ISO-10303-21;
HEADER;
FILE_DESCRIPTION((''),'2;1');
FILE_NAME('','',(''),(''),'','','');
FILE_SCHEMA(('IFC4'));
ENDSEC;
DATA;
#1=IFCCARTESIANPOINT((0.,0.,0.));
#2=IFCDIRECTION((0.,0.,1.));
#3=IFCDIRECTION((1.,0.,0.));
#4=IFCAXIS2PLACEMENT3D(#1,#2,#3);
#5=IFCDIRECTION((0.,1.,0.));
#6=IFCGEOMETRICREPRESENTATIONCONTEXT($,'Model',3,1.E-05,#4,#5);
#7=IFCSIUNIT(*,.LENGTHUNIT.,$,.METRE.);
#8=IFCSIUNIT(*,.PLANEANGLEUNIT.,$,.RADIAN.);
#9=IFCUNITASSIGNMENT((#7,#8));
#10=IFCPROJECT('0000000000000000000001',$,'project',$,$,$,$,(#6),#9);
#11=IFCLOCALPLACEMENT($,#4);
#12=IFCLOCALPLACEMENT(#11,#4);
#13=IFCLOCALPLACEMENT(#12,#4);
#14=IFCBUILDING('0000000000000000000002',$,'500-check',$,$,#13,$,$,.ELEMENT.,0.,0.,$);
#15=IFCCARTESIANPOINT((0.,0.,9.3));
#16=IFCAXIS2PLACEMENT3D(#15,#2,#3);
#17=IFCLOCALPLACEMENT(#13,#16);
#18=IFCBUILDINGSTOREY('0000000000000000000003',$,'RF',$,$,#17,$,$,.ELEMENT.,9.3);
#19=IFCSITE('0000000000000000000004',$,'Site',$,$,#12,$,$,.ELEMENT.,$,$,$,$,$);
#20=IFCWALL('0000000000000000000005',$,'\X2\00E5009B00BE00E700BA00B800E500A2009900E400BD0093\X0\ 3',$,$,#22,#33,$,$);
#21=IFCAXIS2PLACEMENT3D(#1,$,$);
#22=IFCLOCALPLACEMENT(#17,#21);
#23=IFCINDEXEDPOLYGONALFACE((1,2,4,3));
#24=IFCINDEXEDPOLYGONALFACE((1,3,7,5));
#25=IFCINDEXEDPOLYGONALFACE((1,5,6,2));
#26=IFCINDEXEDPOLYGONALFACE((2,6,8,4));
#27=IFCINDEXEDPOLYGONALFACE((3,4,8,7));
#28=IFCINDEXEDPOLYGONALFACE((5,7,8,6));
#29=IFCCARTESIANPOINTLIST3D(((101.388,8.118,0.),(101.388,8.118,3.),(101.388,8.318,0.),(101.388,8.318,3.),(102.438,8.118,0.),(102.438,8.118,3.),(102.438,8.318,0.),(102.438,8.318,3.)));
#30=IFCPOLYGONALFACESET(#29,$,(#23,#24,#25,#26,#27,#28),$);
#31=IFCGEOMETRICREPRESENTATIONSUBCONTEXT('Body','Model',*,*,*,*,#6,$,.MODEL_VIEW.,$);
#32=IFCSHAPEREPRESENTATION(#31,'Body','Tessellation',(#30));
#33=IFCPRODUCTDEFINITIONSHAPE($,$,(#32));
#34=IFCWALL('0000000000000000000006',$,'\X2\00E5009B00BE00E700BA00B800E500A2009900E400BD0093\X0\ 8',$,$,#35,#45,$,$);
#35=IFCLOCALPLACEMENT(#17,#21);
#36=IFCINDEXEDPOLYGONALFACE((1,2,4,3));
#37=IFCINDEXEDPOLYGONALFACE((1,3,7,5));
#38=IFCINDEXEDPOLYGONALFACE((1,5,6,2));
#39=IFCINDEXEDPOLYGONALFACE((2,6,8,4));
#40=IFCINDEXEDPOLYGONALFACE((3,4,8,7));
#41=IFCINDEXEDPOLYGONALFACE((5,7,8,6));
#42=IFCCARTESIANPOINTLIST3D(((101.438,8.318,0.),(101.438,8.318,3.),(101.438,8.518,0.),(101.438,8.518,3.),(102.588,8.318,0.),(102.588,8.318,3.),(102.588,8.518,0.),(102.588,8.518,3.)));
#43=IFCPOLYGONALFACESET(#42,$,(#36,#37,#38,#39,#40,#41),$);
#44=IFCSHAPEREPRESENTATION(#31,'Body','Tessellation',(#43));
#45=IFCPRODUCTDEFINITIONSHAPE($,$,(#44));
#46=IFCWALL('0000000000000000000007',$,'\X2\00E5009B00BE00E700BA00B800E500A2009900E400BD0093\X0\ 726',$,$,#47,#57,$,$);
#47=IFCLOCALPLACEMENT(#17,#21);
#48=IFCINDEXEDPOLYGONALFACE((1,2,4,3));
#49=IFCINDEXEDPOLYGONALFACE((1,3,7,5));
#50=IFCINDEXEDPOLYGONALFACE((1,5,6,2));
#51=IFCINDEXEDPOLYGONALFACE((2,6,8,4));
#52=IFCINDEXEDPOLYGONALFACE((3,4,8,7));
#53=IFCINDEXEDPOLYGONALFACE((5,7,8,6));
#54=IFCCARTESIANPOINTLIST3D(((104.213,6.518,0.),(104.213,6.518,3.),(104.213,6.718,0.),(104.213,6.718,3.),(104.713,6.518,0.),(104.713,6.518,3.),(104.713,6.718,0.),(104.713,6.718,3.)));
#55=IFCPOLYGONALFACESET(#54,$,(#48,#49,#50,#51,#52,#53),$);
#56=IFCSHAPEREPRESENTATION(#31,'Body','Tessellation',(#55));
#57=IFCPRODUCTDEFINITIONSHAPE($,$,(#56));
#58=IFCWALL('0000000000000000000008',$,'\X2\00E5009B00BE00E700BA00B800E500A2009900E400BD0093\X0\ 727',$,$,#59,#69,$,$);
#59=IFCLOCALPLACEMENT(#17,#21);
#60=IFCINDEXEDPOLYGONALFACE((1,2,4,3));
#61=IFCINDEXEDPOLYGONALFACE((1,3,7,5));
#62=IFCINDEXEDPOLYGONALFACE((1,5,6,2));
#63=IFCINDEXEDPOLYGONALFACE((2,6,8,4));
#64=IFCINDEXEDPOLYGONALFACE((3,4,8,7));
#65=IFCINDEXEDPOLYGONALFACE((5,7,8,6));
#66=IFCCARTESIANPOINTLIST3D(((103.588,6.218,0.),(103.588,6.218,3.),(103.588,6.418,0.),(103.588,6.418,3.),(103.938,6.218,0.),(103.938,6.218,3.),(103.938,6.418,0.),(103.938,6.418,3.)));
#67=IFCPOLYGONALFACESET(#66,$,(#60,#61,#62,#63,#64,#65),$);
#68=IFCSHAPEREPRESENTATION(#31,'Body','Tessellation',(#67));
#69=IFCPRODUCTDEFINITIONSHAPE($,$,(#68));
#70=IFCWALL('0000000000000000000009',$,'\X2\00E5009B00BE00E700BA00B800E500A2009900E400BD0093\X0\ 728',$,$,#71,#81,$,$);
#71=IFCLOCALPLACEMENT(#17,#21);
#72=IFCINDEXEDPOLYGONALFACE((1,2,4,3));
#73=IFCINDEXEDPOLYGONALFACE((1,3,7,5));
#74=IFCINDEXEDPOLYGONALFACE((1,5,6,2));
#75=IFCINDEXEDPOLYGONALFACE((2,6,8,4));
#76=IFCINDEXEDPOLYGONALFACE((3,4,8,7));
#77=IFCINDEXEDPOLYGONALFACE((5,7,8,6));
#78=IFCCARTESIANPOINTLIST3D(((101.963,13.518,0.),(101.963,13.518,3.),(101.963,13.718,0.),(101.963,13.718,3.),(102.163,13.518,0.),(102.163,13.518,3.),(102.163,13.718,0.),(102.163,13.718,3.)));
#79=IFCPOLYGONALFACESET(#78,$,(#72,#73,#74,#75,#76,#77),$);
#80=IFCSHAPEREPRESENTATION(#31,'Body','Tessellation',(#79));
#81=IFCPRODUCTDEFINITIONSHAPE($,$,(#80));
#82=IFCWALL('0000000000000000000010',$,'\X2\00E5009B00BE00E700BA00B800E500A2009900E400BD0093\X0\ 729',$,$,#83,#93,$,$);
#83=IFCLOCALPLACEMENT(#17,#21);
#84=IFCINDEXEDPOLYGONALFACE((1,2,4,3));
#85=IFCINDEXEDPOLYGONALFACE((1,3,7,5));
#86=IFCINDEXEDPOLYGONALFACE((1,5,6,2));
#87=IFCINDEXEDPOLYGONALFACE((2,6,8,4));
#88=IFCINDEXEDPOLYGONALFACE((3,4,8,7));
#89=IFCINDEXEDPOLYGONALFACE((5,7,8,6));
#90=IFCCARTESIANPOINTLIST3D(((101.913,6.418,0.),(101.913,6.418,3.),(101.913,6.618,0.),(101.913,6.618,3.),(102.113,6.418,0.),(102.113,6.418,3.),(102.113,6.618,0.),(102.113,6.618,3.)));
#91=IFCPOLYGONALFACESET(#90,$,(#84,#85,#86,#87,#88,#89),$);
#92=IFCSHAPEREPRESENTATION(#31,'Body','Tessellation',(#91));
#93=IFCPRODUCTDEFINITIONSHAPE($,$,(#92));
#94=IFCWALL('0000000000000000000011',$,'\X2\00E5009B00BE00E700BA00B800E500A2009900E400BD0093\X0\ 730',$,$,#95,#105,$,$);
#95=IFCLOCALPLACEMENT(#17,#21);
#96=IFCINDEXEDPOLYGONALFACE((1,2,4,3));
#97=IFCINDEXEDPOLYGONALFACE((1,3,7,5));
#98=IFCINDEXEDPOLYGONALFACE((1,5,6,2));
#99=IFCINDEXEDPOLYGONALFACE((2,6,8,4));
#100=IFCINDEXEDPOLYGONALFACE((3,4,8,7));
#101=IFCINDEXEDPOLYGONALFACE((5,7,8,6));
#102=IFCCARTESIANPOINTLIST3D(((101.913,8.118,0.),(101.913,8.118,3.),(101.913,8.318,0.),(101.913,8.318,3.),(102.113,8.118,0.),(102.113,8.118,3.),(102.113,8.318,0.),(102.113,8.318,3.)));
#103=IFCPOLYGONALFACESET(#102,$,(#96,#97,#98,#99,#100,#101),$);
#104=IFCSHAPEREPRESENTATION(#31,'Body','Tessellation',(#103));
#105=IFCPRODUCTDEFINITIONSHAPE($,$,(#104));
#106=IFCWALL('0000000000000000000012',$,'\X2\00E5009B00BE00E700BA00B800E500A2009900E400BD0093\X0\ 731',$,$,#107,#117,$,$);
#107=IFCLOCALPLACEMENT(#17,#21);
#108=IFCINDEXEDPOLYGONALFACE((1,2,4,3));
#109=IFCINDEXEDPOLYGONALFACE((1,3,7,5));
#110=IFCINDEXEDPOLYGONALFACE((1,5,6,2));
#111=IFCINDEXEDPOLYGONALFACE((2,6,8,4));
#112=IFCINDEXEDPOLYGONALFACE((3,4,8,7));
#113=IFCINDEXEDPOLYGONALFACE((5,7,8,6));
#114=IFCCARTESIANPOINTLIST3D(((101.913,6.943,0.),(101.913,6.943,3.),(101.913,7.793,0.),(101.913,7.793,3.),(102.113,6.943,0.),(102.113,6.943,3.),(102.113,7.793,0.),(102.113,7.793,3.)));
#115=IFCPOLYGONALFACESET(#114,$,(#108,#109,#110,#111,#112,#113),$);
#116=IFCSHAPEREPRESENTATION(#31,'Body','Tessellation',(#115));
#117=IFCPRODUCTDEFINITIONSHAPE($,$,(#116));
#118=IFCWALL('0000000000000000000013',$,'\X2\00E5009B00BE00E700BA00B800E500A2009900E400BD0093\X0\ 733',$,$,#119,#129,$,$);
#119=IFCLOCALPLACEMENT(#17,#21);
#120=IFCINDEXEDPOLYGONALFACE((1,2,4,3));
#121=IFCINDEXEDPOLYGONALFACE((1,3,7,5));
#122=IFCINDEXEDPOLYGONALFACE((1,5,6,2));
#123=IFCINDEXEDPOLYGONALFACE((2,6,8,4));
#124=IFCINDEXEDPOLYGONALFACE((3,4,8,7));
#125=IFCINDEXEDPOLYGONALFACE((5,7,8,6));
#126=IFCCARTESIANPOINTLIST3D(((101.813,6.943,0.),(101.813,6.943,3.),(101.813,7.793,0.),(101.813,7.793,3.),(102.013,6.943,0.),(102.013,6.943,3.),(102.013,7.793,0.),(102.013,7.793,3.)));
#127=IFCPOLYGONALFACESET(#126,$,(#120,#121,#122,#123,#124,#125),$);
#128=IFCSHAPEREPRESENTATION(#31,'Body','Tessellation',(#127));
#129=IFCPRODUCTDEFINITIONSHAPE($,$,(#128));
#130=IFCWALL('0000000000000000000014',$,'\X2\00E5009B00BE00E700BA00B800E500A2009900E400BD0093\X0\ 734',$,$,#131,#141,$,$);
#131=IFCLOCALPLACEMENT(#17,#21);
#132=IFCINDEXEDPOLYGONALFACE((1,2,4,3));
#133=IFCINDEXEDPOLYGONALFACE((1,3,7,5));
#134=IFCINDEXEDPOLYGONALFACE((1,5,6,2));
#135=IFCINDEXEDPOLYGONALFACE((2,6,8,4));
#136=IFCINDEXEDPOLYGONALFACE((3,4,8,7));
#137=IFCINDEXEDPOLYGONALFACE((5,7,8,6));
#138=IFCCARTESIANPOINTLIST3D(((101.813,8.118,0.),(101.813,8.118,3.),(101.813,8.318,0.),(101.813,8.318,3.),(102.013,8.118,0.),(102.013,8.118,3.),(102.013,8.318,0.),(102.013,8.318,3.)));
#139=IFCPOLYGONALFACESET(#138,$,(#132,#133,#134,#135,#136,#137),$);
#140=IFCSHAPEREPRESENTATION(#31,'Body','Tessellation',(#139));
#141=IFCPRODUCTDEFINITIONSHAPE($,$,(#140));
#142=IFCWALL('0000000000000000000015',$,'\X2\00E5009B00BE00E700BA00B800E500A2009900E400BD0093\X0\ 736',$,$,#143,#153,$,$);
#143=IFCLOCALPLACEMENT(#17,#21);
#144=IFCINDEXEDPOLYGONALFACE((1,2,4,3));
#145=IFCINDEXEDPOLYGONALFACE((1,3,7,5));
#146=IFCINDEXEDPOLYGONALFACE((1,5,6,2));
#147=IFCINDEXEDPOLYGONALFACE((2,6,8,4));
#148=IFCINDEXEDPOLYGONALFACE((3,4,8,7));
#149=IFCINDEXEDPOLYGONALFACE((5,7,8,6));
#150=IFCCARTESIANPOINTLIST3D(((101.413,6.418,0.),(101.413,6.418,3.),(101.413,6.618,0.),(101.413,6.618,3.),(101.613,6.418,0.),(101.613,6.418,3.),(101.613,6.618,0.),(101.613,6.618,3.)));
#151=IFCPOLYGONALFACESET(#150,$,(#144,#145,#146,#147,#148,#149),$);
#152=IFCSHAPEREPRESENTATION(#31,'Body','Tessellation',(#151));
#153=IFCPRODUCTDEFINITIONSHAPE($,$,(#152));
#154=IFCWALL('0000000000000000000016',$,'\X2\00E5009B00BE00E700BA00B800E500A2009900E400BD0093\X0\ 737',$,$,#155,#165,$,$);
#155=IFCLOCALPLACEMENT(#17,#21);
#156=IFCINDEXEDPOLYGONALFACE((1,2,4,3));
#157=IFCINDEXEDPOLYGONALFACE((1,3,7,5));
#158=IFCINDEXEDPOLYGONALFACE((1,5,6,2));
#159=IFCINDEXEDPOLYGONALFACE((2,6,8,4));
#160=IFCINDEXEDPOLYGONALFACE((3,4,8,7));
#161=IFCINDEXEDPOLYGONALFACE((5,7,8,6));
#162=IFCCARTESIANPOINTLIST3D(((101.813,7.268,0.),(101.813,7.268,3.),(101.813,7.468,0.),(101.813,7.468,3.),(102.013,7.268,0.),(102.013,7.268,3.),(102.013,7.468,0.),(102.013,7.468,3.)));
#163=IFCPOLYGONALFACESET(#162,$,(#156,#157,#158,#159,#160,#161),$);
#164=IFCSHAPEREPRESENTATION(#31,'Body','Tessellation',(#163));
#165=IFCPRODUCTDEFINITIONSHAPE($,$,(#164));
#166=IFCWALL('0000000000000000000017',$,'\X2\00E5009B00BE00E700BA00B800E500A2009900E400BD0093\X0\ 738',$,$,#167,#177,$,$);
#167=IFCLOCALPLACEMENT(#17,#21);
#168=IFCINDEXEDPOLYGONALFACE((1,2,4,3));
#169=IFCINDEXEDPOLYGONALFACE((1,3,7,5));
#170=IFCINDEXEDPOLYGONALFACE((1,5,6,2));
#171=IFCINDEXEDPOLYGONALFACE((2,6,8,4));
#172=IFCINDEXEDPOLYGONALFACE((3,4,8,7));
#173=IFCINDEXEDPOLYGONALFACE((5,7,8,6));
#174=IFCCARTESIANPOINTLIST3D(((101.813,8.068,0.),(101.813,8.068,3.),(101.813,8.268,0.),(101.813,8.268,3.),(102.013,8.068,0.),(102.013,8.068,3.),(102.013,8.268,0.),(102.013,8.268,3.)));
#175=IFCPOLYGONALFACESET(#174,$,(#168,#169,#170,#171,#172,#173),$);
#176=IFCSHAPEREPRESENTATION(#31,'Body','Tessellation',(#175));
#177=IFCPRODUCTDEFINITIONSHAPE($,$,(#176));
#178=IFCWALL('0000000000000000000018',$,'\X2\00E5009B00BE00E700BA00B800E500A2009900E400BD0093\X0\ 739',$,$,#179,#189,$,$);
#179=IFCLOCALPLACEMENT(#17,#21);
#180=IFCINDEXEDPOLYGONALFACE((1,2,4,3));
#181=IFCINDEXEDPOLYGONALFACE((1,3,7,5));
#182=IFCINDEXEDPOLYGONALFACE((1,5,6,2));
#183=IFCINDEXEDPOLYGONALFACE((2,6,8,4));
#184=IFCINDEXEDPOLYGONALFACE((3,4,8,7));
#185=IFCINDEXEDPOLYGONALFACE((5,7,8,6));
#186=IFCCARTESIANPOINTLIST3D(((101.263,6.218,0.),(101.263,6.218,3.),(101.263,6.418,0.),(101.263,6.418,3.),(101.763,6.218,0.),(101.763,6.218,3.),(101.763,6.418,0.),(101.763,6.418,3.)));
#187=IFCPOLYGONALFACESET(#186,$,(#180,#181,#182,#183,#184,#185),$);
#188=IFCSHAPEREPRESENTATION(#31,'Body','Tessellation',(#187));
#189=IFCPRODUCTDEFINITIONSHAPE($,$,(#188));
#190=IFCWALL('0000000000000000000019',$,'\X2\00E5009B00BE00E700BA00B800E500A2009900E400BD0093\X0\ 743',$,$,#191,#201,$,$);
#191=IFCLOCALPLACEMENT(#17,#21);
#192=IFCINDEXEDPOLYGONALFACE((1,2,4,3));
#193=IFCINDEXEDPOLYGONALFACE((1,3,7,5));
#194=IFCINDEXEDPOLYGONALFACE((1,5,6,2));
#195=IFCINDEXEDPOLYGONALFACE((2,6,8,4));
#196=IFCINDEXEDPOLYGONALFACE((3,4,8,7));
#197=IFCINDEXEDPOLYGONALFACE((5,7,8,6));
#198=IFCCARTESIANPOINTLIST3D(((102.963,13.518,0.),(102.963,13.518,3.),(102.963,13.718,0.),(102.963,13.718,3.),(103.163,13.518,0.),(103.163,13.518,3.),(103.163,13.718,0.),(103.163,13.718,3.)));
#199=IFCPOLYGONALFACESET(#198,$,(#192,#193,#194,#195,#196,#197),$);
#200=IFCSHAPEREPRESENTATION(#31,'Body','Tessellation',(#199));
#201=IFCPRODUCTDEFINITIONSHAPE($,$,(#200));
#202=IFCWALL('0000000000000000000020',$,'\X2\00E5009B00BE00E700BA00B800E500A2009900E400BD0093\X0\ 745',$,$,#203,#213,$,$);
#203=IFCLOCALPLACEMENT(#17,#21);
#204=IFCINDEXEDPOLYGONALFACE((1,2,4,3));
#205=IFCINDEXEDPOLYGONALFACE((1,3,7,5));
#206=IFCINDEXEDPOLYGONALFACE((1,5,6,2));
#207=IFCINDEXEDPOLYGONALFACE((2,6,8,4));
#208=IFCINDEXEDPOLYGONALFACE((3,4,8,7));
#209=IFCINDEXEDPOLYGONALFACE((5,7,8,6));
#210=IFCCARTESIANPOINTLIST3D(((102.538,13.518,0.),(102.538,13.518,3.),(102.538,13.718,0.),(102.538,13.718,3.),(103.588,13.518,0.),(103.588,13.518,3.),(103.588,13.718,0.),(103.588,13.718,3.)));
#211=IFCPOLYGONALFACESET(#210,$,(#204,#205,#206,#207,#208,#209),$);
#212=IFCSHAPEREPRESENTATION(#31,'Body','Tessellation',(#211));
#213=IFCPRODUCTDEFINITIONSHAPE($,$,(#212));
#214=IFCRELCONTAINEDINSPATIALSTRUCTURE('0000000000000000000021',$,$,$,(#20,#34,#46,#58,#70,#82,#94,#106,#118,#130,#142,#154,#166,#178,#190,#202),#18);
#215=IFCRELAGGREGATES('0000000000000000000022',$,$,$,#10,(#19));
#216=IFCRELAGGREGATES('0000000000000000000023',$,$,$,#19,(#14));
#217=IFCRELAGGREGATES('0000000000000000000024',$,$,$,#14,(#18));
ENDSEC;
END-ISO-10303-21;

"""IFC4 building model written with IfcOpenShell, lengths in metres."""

from ifc_helpers import new_model, si_unit, direction, frame, frame_2d, origin_with_axes, place, context, subcontext, project, spatial, rectangle, extrude, element, save


model = new_model("IFC4")

# Units and contexts
model_context = context("Model", 3, precision=1e-05, world=origin_with_axes(), true_north=direction((0.0, 1.0, 0.0)))
body_context = subcontext(model_context, "Body", "Model", "MODEL_VIEW")
ifc_project = project(units=[si_unit("LENGTHUNIT", "METRE"), si_unit("PLANEANGLEUNIT", "RADIAN")], contexts=[model_context])

# Site, building, storey
placement = place(None, origin_with_axes())
site_placement = place(placement, origin_with_axes())
site = spatial("IfcSite", under=ifc_project, at=site_placement, Name="Site", CompositionType="ELEMENT")
building_placement = place(site_placement, origin_with_axes())
building = spatial("IfcBuilding", under=site, at=building_placement, Name="500-check", CompositionType="ELEMENT", ElevationOfRefHeight=0.0, ElevationOfTerrain=0.0)
storey_placement = place(building_placement, frame((0.0, 0.0, 9.3), z_axis=(0.0, 0.0, 1.0), x_axis=(1.0, 0.0, 0.0)))
storey = spatial("IfcBuildingStorey", under=building, at=storey_placement, Name="RF", CompositionType="ELEMENT", Elevation=9.3)

# Walls
wall_1_placement = place(storey_placement, frame((101.913, 8.218, 0.0), z_axis=(0.0, 0.0, 1.0), x_axis=(-1.0, 0.0, 0.0)))
element("IfcWall", 1, at=wall_1_placement, inside=storey, Name="å\u009b¾çº¸å¢\u0099ä½\u0093 3", context=body_context, shape_type="SweptSolid", body=[
    extrude(rectangle(XDim=1.05, YDim=0.2, at=frame_2d((0.0, 0.0), x_axis=(1.0, 0.0, 0.0))), frame((0.0, 0.0, 0.0), z_axis=(0.0, 0.0, 1.0)), (0.0, 0.0, 1.0), 3.0),
])
wall_2_placement = place(storey_placement, frame((102.013, 8.418, 0.0), z_axis=(0.0, 0.0, 1.0), x_axis=(-1.0, 0.0, 0.0)))
element("IfcWall", 2, at=wall_2_placement, inside=storey, Name="å\u009b¾çº¸å¢\u0099ä½\u0093 8", context=body_context, shape_type="SweptSolid", body=[
    extrude(rectangle(XDim=1.15, YDim=0.2, at=frame_2d((0.0, 0.0), x_axis=(1.0, 0.0, 0.0))), frame((0.0, 0.0, 0.0), z_axis=(0.0, 0.0, 1.0)), (0.0, 0.0, 1.0), 3.0),
])
wall_3_placement = place(storey_placement, frame((104.463, 6.618, 0.0), z_axis=(0.0, 0.0, 1.0), x_axis=(1.0, 0.0, 0.0)))
element("IfcWall", 3, at=wall_3_placement, inside=storey, Name="å\u009b¾çº¸å¢\u0099ä½\u0093 726", context=body_context, shape_type="SweptSolid", body=[
    extrude(rectangle(XDim=0.5, YDim=0.2, at=frame_2d((0.0, 0.0), x_axis=(1.0, 0.0, 0.0))), frame((0.0, 0.0, 0.0), z_axis=(0.0, 0.0, 1.0)), (0.0, 0.0, 1.0), 3.0),
])
wall_4_placement = place(storey_placement, frame((103.763, 6.318, 0.0), z_axis=(0.0, 0.0, 1.0), x_axis=(1.0, 0.0, 0.0)))
element("IfcWall", 4, at=wall_4_placement, inside=storey, Name="å\u009b¾çº¸å¢\u0099ä½\u0093 727", context=body_context, shape_type="SweptSolid", body=[
    extrude(rectangle(XDim=0.35, YDim=0.2, at=frame_2d((0.0, 0.0), x_axis=(1.0, 0.0, 0.0))), frame((0.0, 0.0, 0.0), z_axis=(0.0, 0.0, 1.0)), (0.0, 0.0, 1.0), 3.0),
])
for number, where, z_axis, x_axis, name in (
    (5, (102.063, 13.618, 0.0), (0.0, 0.0, 1.0), (0.0, 1.0, 0.0), "å\u009b¾çº¸å¢\u0099ä½\u0093 728"),
    (6, (102.013, 6.518, 0.0), (0.0, 0.0, 1.0), (0.0, -1.0, 0.0), "å\u009b¾çº¸å¢\u0099ä½\u0093 729"),
    (7, (102.013, 8.218, 0.0), (0.0, 0.0, 1.0), (0.0, 1.0, 0.0), "å\u009b¾çº¸å¢\u0099ä½\u0093 730"),
):
    element("IfcWall", number, at=place(storey_placement, frame(where, z_axis=z_axis, x_axis=x_axis)), inside=storey, Name=name, context=body_context, shape_type="SweptSolid", body=[
        extrude(rectangle(XDim=0.2, YDim=0.2, at=frame_2d((0.0, 0.0), x_axis=(1.0, 0.0, 0.0))), frame((0.0, 0.0, 0.0), z_axis=(0.0, 0.0, 1.0)), (0.0, 0.0, 1.0), 3.0),
    ])
wall_5_placement = place(storey_placement, frame((102.013, 7.368, 0.0), z_axis=(0.0, 0.0, 1.0), x_axis=(0.0, -1.0, 0.0)))
element("IfcWall", 8, at=wall_5_placement, inside=storey, Name="å\u009b¾çº¸å¢\u0099ä½\u0093 731", context=body_context, shape_type="SweptSolid", body=[
    extrude(rectangle(XDim=0.85, YDim=0.2, at=frame_2d((0.0, 0.0), x_axis=(1.0, 0.0, 0.0))), frame((0.0, 0.0, 0.0), z_axis=(0.0, 0.0, 1.0)), (0.0, 0.0, 1.0), 3.0),
])
wall_6_placement = place(storey_placement, frame((101.913, 7.368, 0.0), z_axis=(0.0, 0.0, 1.0), x_axis=(0.0, -1.0, 0.0)))
element("IfcWall", 9, at=wall_6_placement, inside=storey, Name="å\u009b¾çº¸å¢\u0099ä½\u0093 733", context=body_context, shape_type="SweptSolid", body=[
    extrude(rectangle(XDim=0.85, YDim=0.2, at=frame_2d((0.0, 0.0), x_axis=(1.0, 0.0, 0.0))), frame((0.0, 0.0, 0.0), z_axis=(0.0, 0.0, 1.0)), (0.0, 0.0, 1.0), 3.0),
])
for number, where, z_axis, x_axis, name in (
    (10, (101.913, 8.218, 0.0), (0.0, 0.0, 1.0), (0.0, -1.0, 0.0), "å\u009b¾çº¸å¢\u0099ä½\u0093 734"),
    (11, (101.513, 6.518, 0.0), (0.0, 0.0, 1.0), (0.0, -1.0, 0.0), "å\u009b¾çº¸å¢\u0099ä½\u0093 736"),
    (12, (101.913, 7.368, 0.0), (0.0, 0.0, 1.0), (1.0, 0.0, 0.0), "å\u009b¾çº¸å¢\u0099ä½\u0093 737"),
    (13, (101.913, 8.168, 0.0), (0.0, 0.0, 1.0), (1.0, 0.0, 0.0), "å\u009b¾çº¸å¢\u0099ä½\u0093 738"),
):
    element("IfcWall", number, at=place(storey_placement, frame(where, z_axis=z_axis, x_axis=x_axis)), inside=storey, Name=name, context=body_context, shape_type="SweptSolid", body=[
        extrude(rectangle(XDim=0.2, YDim=0.2, at=frame_2d((0.0, 0.0), x_axis=(1.0, 0.0, 0.0))), frame((0.0, 0.0, 0.0), z_axis=(0.0, 0.0, 1.0)), (0.0, 0.0, 1.0), 3.0),
    ])
wall_7_placement = place(storey_placement, frame((101.513, 6.318, 0.0), z_axis=(0.0, 0.0, 1.0), x_axis=(1.0, 0.0, 0.0)))
element("IfcWall", 14, at=wall_7_placement, inside=storey, Name="å\u009b¾çº¸å¢\u0099ä½\u0093 739", context=body_context, shape_type="SweptSolid", body=[
    extrude(rectangle(XDim=0.5, YDim=0.2, at=frame_2d((0.0, 0.0), x_axis=(1.0, 0.0, 0.0))), frame((0.0, 0.0, 0.0), z_axis=(0.0, 0.0, 1.0)), (0.0, 0.0, 1.0), 3.0),
])
wall_8_placement = place(storey_placement, frame((103.063, 13.618, 0.0), z_axis=(0.0, 0.0, 1.0), x_axis=(0.0, 1.0, 0.0)))
element("IfcWall", 15, at=wall_8_placement, inside=storey, Name="å\u009b¾çº¸å¢\u0099ä½\u0093 743", context=body_context, shape_type="SweptSolid", body=[
    extrude(rectangle(XDim=0.2, YDim=0.2, at=frame_2d((0.0, 0.0), x_axis=(1.0, 0.0, 0.0))), frame((0.0, 0.0, 0.0), z_axis=(0.0, 0.0, 1.0)), (0.0, 0.0, 1.0), 3.0),
])
wall_9_placement = place(storey_placement, frame((103.063, 13.618, 0.0), z_axis=(0.0, 0.0, 1.0), x_axis=(1.0, 0.0, 0.0)))
element("IfcWall", 16, at=wall_9_placement, inside=storey, Name="å\u009b¾çº¸å¢\u0099ä½\u0093 745", context=body_context, shape_type="SweptSolid", body=[
    extrude(rectangle(XDim=1.05, YDim=0.2, at=frame_2d((0.0, 0.0), x_axis=(1.0, 0.0, 0.0))), frame((0.0, 0.0, 0.0), z_axis=(0.0, 0.0, 1.0)), (0.0, 0.0, 1.0), 3.0),
])

save(model, "model.ifc")
